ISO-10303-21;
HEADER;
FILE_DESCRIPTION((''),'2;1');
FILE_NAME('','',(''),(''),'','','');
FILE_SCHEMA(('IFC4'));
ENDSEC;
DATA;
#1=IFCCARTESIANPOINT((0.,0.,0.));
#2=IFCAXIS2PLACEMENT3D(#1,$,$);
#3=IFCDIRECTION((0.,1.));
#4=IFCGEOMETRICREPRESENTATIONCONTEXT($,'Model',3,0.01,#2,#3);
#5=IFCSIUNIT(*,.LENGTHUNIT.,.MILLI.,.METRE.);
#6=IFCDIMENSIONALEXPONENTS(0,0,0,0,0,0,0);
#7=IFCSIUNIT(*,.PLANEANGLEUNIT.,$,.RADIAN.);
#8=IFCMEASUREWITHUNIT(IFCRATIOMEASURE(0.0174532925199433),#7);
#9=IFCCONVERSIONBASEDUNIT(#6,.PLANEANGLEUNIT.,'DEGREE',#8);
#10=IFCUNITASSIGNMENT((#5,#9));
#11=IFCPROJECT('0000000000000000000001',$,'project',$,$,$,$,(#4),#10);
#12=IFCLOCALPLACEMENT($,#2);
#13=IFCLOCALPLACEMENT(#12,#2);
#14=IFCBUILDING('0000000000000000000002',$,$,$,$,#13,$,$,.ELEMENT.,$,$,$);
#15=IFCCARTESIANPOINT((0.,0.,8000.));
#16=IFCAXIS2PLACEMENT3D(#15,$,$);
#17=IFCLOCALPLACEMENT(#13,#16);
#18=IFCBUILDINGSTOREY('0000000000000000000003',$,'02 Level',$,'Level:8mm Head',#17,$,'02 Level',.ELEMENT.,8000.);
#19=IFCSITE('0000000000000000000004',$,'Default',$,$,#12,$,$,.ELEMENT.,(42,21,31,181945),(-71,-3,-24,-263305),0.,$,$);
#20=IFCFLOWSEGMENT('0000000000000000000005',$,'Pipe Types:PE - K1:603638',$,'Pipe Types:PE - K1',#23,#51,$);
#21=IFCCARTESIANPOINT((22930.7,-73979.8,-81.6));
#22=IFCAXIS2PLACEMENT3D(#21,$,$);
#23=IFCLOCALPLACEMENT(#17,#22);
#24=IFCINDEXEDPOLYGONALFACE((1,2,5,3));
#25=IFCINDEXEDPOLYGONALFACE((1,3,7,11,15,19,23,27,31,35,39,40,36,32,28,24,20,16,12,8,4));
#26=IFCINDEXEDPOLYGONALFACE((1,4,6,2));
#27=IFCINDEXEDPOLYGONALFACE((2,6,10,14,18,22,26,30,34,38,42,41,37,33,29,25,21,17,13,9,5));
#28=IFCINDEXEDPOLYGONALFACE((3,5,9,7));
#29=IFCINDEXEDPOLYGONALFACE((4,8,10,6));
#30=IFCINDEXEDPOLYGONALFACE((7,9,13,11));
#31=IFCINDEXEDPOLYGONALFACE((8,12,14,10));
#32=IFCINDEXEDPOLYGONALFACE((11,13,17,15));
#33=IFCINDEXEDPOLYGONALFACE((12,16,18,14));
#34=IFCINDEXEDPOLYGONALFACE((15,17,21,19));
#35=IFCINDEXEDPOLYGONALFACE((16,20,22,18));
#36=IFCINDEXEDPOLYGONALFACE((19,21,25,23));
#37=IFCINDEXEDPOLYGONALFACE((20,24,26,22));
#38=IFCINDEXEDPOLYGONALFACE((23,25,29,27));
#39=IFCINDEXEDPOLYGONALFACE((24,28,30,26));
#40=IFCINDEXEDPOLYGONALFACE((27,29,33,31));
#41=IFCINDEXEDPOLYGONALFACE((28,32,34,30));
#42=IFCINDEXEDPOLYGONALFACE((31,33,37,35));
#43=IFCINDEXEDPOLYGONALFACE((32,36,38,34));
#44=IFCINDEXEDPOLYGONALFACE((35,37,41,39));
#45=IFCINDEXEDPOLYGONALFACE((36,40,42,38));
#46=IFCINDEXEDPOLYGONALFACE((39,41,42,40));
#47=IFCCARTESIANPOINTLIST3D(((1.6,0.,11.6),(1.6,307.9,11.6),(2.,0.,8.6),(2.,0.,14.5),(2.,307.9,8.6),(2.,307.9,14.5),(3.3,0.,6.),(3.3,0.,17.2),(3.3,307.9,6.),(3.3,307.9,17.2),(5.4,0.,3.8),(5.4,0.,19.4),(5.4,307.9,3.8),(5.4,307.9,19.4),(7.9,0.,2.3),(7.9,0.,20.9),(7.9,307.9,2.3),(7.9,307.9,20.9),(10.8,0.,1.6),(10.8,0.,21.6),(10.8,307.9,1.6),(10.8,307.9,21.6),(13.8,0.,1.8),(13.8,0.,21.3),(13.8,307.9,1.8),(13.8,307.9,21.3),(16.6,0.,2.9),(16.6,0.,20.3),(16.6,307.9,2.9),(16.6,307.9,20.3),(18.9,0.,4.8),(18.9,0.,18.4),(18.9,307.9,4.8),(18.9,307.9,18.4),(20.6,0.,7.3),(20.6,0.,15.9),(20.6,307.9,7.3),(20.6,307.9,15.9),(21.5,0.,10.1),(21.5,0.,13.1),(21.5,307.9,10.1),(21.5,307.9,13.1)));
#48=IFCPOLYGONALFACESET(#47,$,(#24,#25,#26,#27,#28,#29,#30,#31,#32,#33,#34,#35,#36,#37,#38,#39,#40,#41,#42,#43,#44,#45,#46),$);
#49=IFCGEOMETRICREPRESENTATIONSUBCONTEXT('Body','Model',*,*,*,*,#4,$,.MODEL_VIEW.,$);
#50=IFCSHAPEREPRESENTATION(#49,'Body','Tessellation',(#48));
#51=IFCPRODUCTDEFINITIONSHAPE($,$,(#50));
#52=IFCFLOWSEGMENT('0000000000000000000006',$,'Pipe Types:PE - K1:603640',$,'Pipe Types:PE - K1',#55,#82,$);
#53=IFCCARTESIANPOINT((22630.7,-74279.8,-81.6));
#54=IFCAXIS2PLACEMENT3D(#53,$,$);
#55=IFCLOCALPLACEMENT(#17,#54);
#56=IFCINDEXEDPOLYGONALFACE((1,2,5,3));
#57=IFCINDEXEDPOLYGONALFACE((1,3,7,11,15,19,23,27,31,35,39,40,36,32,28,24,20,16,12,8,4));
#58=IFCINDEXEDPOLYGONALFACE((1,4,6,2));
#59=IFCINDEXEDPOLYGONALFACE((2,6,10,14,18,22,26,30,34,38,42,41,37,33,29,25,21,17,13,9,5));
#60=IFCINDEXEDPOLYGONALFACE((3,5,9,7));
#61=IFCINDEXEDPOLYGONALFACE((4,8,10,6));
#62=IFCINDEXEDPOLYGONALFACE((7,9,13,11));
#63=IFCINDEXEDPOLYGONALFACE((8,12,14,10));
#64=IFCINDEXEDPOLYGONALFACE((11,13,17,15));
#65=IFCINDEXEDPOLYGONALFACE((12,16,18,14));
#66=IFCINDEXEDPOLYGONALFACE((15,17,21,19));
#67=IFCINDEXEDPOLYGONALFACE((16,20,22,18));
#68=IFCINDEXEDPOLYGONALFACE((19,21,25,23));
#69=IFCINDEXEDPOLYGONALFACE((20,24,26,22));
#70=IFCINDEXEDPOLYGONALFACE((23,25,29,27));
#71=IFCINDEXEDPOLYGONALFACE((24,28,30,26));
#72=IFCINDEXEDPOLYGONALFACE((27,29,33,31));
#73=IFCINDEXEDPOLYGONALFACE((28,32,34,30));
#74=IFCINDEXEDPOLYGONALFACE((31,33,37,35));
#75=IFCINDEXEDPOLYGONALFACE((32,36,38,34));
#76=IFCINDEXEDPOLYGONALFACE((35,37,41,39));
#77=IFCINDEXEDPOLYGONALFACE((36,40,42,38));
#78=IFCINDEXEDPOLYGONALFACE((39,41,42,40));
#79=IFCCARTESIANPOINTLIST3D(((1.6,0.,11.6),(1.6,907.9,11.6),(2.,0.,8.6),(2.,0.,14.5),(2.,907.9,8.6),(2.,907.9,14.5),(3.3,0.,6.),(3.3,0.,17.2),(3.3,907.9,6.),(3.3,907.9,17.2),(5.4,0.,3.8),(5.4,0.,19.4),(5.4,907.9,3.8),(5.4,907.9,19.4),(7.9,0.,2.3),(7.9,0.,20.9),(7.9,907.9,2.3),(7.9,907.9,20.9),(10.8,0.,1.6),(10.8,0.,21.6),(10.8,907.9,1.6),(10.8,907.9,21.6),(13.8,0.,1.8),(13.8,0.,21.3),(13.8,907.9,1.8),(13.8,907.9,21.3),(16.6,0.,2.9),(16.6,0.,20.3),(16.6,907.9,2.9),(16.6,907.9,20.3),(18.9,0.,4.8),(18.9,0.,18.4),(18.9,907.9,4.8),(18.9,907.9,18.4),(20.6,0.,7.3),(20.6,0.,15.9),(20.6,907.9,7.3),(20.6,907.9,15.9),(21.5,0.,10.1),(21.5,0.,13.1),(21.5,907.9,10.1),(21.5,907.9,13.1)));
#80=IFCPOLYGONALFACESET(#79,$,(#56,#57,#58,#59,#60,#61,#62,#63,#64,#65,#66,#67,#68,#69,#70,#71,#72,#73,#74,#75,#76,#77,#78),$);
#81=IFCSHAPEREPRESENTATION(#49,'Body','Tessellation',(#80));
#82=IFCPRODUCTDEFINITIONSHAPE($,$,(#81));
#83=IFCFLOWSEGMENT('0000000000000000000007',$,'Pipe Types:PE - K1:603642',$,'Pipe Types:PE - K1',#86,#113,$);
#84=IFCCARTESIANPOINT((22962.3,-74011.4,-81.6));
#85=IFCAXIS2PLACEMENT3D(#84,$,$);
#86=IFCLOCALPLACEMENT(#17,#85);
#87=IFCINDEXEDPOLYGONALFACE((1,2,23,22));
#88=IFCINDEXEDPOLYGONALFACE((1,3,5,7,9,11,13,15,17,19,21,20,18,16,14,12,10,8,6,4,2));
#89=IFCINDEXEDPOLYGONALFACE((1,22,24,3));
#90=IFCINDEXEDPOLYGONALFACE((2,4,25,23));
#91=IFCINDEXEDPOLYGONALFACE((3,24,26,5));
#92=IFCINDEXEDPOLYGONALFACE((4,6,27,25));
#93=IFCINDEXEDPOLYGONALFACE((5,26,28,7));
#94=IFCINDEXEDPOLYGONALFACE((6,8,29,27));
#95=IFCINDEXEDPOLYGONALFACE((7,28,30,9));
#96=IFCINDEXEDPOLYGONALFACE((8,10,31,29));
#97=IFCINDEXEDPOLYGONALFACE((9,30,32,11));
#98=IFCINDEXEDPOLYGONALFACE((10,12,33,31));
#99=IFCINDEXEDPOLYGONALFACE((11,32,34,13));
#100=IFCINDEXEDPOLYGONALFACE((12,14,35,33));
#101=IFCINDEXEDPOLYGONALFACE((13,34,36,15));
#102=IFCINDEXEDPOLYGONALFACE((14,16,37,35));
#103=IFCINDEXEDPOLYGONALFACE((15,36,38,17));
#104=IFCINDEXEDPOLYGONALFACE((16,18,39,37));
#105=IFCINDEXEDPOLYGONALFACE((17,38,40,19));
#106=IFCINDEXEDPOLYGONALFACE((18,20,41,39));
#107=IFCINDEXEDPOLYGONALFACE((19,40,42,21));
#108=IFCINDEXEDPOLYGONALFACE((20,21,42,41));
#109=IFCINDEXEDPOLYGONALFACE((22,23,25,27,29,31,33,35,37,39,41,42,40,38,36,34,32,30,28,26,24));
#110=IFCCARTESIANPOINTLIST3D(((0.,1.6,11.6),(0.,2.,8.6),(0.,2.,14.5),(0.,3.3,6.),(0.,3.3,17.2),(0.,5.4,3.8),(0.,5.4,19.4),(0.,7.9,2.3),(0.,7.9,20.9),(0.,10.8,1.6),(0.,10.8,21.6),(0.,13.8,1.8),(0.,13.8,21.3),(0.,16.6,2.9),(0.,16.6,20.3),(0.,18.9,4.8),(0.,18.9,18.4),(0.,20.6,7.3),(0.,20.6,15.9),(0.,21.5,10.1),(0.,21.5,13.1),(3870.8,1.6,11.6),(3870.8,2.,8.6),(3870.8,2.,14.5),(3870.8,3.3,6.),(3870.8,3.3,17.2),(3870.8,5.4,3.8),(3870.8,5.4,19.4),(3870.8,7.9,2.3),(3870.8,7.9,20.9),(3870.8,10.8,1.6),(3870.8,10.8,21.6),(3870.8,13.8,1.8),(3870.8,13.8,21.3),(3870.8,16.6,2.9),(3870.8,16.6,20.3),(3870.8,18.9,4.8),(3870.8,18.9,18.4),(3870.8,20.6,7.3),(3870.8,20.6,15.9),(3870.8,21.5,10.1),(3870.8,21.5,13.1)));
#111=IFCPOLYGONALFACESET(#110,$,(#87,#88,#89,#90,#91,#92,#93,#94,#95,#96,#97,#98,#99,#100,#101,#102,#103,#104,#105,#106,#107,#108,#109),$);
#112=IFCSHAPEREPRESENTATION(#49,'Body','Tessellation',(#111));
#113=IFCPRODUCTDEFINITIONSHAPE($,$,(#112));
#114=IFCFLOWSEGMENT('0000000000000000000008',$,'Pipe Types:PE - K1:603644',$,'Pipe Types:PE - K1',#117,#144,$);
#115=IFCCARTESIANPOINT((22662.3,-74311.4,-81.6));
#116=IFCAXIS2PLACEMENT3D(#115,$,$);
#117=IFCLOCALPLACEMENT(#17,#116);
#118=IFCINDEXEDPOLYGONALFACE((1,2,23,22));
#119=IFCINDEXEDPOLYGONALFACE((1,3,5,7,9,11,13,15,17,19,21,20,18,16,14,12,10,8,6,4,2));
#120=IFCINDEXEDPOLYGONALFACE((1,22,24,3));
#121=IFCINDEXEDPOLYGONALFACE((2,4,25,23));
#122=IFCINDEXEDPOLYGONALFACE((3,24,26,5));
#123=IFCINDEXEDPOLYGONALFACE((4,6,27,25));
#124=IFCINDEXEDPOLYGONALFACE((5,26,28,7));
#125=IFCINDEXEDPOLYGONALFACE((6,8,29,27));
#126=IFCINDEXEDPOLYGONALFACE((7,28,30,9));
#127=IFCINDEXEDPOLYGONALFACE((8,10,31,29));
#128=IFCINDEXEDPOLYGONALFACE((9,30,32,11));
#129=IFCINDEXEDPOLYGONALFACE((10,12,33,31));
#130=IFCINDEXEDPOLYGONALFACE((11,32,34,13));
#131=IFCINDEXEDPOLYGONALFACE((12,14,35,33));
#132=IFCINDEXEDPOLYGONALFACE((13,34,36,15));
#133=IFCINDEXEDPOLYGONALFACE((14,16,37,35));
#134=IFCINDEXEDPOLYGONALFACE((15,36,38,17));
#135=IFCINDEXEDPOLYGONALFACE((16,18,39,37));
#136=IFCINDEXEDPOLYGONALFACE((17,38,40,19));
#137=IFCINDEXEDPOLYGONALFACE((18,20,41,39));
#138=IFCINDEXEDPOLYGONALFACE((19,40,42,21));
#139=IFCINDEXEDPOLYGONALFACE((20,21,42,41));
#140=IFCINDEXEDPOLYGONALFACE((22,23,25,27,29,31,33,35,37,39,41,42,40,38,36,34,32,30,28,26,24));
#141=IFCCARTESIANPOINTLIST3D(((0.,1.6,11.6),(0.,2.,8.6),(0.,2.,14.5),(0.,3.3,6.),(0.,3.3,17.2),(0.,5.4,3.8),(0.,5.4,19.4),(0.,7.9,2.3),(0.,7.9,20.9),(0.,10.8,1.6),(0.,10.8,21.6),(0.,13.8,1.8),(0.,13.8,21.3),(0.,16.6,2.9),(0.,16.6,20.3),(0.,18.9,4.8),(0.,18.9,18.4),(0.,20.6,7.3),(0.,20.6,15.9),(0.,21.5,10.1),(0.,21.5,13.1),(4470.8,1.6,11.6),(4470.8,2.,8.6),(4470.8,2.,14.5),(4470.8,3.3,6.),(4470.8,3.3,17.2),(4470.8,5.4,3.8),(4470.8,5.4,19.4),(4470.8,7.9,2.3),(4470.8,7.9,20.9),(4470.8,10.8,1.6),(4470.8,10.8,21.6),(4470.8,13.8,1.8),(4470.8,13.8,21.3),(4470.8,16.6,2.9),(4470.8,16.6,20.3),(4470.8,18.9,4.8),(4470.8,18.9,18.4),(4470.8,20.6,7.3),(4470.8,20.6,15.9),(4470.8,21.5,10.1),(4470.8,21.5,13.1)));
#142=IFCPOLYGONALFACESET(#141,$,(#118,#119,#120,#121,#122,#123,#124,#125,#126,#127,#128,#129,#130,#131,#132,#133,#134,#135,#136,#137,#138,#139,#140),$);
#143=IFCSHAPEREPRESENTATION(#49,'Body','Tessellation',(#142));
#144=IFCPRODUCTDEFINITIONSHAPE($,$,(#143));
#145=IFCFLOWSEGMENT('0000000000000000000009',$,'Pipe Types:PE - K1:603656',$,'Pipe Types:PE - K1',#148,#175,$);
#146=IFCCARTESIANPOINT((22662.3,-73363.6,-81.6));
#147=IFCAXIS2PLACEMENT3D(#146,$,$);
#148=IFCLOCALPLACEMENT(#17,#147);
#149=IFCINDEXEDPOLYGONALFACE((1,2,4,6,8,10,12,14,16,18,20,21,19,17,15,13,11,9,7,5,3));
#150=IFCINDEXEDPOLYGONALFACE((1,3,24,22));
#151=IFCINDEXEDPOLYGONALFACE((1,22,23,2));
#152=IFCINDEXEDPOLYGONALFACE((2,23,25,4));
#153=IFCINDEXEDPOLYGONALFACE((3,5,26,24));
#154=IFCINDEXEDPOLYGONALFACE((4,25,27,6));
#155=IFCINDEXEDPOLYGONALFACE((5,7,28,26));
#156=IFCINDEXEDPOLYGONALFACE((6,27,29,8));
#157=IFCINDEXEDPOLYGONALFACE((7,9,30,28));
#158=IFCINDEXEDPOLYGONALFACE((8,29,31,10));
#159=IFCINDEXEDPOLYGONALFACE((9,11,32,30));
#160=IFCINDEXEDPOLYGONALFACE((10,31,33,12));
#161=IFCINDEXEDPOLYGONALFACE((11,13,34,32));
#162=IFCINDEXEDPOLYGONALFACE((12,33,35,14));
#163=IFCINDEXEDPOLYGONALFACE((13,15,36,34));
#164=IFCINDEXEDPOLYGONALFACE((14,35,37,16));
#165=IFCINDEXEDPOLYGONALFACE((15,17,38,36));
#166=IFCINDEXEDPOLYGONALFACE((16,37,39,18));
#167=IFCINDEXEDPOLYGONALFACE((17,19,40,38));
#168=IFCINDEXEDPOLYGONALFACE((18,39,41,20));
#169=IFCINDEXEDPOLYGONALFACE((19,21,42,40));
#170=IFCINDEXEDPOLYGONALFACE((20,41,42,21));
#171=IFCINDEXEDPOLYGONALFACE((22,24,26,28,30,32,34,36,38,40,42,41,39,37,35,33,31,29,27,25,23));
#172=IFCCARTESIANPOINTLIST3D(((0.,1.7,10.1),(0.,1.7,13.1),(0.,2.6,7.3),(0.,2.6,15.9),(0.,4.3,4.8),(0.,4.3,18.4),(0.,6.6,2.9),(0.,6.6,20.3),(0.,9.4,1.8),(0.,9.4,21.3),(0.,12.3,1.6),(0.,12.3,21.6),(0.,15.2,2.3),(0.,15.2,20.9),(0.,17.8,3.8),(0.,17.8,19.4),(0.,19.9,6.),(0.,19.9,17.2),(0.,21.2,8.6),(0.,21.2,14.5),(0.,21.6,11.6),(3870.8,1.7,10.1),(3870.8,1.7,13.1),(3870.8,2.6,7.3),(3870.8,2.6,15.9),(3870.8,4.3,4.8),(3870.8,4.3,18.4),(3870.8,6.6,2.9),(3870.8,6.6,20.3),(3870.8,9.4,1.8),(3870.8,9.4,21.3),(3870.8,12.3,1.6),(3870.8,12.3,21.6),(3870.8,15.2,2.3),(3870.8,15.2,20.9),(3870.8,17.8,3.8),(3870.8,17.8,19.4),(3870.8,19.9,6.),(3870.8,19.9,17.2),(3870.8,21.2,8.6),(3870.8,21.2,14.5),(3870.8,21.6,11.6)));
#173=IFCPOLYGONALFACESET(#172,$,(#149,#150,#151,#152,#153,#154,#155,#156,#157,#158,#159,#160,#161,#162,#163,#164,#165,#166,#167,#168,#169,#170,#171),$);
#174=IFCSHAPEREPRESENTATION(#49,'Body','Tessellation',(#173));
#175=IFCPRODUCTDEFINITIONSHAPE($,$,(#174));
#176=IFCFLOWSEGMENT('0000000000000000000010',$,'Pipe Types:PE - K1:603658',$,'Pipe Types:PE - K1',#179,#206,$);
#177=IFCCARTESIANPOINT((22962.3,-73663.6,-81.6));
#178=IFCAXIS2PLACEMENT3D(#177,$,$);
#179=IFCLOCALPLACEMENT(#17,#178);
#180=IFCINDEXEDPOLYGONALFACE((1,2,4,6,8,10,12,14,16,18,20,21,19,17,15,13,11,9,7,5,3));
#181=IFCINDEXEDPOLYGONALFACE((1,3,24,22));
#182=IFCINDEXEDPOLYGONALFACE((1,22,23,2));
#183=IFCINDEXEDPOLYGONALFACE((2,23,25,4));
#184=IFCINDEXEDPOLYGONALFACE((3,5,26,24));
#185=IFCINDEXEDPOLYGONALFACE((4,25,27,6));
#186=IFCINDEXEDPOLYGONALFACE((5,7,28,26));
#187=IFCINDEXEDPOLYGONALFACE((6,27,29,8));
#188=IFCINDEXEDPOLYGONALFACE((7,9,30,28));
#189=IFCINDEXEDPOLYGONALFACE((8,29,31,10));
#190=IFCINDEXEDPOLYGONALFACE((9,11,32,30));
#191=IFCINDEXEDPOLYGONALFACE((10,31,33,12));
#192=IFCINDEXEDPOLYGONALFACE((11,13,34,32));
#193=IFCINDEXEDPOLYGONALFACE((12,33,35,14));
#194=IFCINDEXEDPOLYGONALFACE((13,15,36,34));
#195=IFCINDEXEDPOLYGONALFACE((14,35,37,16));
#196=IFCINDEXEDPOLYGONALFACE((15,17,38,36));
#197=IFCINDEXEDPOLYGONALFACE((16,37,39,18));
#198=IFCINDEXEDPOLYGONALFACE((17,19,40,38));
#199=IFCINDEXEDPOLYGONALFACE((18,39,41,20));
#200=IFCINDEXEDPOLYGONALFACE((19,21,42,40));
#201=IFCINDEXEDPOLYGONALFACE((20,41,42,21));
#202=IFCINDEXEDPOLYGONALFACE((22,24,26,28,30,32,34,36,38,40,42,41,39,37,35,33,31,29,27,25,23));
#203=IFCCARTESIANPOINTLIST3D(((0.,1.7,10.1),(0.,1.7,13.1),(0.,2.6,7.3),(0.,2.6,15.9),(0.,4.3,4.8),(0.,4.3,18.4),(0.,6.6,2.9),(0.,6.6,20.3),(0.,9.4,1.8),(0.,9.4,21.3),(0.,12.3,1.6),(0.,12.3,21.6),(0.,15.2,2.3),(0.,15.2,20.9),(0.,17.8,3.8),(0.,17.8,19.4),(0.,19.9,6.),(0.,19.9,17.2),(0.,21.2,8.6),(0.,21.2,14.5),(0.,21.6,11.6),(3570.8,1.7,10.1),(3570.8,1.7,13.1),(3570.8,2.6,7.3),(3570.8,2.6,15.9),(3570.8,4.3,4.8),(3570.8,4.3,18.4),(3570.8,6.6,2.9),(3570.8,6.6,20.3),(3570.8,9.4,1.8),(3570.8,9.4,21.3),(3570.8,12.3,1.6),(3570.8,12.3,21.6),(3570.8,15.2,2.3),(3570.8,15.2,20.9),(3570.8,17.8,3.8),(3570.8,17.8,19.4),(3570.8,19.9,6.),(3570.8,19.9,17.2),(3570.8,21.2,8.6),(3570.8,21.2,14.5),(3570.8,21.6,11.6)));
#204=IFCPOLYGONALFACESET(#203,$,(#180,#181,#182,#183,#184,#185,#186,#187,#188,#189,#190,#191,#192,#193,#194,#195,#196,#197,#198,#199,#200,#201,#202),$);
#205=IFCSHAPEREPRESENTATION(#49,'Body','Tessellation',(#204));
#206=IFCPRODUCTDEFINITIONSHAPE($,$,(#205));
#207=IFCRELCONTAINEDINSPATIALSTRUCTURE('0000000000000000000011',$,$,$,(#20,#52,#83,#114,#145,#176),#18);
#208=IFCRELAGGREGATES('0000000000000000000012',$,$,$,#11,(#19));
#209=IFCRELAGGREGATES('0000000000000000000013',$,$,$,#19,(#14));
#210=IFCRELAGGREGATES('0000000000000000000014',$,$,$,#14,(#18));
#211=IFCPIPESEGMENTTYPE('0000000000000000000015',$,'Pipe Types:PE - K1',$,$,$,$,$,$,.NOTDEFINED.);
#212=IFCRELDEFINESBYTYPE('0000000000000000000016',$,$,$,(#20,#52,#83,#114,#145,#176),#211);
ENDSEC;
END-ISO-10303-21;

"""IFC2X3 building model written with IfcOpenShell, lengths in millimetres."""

from ifc_helpers import new_model, entity, si_unit, converted_unit, direction, frame, frame_2d, origin, origin_2d_with_axis, place, context, subcontext, project, spatial, circle, extrude, type_object, element, save


model = new_model("IFC2X3")

# Units and contexts
model_context = context("Model", 3, precision=0.01, world=origin(), true_north=direction((0.0, 1.0)))
body_context = subcontext(model_context, "Body", "Model", "MODEL_VIEW")
ifc_project = project(units=[si_unit("LENGTHUNIT", "METRE", prefix="MILLI"), converted_unit("PLANEANGLEUNIT", "DEGREE", entity("IfcRatioMeasure", 0.0174532925199433), si_unit("PLANEANGLEUNIT", "RADIAN"), dimensions=[0, 0, 0, 0, 0, 0, 0])], contexts=[model_context])

# Site, building, storey
site_placement = place(None, origin())
site = spatial("IfcSite", under=ifc_project, at=site_placement, Name="Default", CompositionType="ELEMENT", RefLatitude=(42, 21, 31, 181945), RefLongitude=(-71, -3, -24, -263305), RefElevation=0.0)
building_placement = place(site_placement, origin())
building = spatial("IfcBuilding", under=site, at=building_placement, CompositionType="ELEMENT")
storey_placement = place(building_placement, frame((0.0, 0.0, 8000.0)))
storey = spatial("IfcBuildingStorey", under=building, at=storey_placement, Name="02 Level", ObjectType="Level:8mm Head", LongName="02 Level", CompositionType="ELEMENT", Elevation=8000.0)

# Flow segments
pipe_segment_type = type_object("IfcPipeSegmentType", Name="Pipe Types:PE - K1", PredefinedType="NOTDEFINED")
flow_segment_1_placement = place(storey_placement, frame((22930.7, -73979.8, -81.6)))
element("IfcFlowSegment", 1, at=flow_segment_1_placement, inside=storey, type_object=pipe_segment_type, Name="Pipe Types:PE - K1:603638", ObjectType="Pipe Types:PE - K1", context=body_context, shape_type="SweptSolid", body=[
    extrude(circle(Radius=10.0, at=frame_2d((0.0, 0.0), x_axis=(1.0, 0.0))), frame((11.6, 0.0, 11.6), z_axis=(0.0, 1.0, 0.0), x_axis=(-1.0, 0.0, 0.0)), (0.0, 0.0, 1.0), 307.9),
])
flow_segment_2_placement = place(storey_placement, frame((22630.7, -74279.8, -81.6)))
element("IfcFlowSegment", 2, at=flow_segment_2_placement, inside=storey, type_object=pipe_segment_type, Name="Pipe Types:PE - K1:603640", ObjectType="Pipe Types:PE - K1", context=body_context, shape_type="SweptSolid", body=[
    extrude(circle(Radius=10.0, at=frame_2d((0.0, 0.0), x_axis=(1.0, 0.0))), frame((11.6, 0.0, 11.6), z_axis=(0.0, 1.0, 0.0), x_axis=(-1.0, 0.0, 0.0)), (0.0, 0.0, 1.0), 907.9),
])
flow_segment_3_placement = place(storey_placement, frame((22962.3, -74011.4, -81.6)))
element("IfcFlowSegment", 3, at=flow_segment_3_placement, inside=storey, type_object=pipe_segment_type, Name="Pipe Types:PE - K1:603642", ObjectType="Pipe Types:PE - K1", context=body_context, shape_type="SweptSolid", body=[
    extrude(circle(Radius=10.0, at=origin_2d_with_axis()), frame((0.0, 11.6, 11.6), z_axis=(1.0, 0.0, 0.0), x_axis=(0.0, -1.0, 0.0)), (0.0, 0.0, 1.0), 3870.8),
])
flow_segment_4_placement = place(storey_placement, frame((22662.3, -74311.4, -81.6)))
element("IfcFlowSegment", 4, at=flow_segment_4_placement, inside=storey, type_object=pipe_segment_type, Name="Pipe Types:PE - K1:603644", ObjectType="Pipe Types:PE - K1", context=body_context, shape_type="SweptSolid", body=[
    extrude(circle(Radius=10.0, at=origin_2d_with_axis()), frame((0.0, 11.6, 11.6), z_axis=(1.0, 0.0, 0.0), x_axis=(0.0, -1.0, 0.0)), (0.0, 0.0, 1.0), 4470.8),
])
flow_segment_5_placement = place(storey_placement, frame((22662.3, -73363.6, -81.6)))
element("IfcFlowSegment", 5, at=flow_segment_5_placement, inside=storey, type_object=pipe_segment_type, Name="Pipe Types:PE - K1:603656", ObjectType="Pipe Types:PE - K1", context=body_context, shape_type="SweptSolid", body=[
    extrude(circle(Radius=10.0, at=frame_2d((0.0, 0.0), x_axis=(1.0, 0.0))), frame((0.0, 11.6, 11.6), z_axis=(1.0, 0.0, 0.0), x_axis=(0.0, 1.0, 0.0)), (0.0, 0.0, 1.0), 3870.8),
])
flow_segment_6_placement = place(storey_placement, frame((22962.3, -73663.6, -81.6)))
element("IfcFlowSegment", 6, at=flow_segment_6_placement, inside=storey, type_object=pipe_segment_type, Name="Pipe Types:PE - K1:603658", ObjectType="Pipe Types:PE - K1", context=body_context, shape_type="SweptSolid", body=[
    extrude(circle(Radius=10.0, at=frame_2d((0.0, 0.0), x_axis=(1.0, 0.0))), frame((0.0, 11.6, 11.6), z_axis=(1.0, 0.0, 0.0), x_axis=(0.0, 1.0, 0.0)), (0.0, 0.0, 1.0), 3570.8),
])

save(model, "model.ifc")
